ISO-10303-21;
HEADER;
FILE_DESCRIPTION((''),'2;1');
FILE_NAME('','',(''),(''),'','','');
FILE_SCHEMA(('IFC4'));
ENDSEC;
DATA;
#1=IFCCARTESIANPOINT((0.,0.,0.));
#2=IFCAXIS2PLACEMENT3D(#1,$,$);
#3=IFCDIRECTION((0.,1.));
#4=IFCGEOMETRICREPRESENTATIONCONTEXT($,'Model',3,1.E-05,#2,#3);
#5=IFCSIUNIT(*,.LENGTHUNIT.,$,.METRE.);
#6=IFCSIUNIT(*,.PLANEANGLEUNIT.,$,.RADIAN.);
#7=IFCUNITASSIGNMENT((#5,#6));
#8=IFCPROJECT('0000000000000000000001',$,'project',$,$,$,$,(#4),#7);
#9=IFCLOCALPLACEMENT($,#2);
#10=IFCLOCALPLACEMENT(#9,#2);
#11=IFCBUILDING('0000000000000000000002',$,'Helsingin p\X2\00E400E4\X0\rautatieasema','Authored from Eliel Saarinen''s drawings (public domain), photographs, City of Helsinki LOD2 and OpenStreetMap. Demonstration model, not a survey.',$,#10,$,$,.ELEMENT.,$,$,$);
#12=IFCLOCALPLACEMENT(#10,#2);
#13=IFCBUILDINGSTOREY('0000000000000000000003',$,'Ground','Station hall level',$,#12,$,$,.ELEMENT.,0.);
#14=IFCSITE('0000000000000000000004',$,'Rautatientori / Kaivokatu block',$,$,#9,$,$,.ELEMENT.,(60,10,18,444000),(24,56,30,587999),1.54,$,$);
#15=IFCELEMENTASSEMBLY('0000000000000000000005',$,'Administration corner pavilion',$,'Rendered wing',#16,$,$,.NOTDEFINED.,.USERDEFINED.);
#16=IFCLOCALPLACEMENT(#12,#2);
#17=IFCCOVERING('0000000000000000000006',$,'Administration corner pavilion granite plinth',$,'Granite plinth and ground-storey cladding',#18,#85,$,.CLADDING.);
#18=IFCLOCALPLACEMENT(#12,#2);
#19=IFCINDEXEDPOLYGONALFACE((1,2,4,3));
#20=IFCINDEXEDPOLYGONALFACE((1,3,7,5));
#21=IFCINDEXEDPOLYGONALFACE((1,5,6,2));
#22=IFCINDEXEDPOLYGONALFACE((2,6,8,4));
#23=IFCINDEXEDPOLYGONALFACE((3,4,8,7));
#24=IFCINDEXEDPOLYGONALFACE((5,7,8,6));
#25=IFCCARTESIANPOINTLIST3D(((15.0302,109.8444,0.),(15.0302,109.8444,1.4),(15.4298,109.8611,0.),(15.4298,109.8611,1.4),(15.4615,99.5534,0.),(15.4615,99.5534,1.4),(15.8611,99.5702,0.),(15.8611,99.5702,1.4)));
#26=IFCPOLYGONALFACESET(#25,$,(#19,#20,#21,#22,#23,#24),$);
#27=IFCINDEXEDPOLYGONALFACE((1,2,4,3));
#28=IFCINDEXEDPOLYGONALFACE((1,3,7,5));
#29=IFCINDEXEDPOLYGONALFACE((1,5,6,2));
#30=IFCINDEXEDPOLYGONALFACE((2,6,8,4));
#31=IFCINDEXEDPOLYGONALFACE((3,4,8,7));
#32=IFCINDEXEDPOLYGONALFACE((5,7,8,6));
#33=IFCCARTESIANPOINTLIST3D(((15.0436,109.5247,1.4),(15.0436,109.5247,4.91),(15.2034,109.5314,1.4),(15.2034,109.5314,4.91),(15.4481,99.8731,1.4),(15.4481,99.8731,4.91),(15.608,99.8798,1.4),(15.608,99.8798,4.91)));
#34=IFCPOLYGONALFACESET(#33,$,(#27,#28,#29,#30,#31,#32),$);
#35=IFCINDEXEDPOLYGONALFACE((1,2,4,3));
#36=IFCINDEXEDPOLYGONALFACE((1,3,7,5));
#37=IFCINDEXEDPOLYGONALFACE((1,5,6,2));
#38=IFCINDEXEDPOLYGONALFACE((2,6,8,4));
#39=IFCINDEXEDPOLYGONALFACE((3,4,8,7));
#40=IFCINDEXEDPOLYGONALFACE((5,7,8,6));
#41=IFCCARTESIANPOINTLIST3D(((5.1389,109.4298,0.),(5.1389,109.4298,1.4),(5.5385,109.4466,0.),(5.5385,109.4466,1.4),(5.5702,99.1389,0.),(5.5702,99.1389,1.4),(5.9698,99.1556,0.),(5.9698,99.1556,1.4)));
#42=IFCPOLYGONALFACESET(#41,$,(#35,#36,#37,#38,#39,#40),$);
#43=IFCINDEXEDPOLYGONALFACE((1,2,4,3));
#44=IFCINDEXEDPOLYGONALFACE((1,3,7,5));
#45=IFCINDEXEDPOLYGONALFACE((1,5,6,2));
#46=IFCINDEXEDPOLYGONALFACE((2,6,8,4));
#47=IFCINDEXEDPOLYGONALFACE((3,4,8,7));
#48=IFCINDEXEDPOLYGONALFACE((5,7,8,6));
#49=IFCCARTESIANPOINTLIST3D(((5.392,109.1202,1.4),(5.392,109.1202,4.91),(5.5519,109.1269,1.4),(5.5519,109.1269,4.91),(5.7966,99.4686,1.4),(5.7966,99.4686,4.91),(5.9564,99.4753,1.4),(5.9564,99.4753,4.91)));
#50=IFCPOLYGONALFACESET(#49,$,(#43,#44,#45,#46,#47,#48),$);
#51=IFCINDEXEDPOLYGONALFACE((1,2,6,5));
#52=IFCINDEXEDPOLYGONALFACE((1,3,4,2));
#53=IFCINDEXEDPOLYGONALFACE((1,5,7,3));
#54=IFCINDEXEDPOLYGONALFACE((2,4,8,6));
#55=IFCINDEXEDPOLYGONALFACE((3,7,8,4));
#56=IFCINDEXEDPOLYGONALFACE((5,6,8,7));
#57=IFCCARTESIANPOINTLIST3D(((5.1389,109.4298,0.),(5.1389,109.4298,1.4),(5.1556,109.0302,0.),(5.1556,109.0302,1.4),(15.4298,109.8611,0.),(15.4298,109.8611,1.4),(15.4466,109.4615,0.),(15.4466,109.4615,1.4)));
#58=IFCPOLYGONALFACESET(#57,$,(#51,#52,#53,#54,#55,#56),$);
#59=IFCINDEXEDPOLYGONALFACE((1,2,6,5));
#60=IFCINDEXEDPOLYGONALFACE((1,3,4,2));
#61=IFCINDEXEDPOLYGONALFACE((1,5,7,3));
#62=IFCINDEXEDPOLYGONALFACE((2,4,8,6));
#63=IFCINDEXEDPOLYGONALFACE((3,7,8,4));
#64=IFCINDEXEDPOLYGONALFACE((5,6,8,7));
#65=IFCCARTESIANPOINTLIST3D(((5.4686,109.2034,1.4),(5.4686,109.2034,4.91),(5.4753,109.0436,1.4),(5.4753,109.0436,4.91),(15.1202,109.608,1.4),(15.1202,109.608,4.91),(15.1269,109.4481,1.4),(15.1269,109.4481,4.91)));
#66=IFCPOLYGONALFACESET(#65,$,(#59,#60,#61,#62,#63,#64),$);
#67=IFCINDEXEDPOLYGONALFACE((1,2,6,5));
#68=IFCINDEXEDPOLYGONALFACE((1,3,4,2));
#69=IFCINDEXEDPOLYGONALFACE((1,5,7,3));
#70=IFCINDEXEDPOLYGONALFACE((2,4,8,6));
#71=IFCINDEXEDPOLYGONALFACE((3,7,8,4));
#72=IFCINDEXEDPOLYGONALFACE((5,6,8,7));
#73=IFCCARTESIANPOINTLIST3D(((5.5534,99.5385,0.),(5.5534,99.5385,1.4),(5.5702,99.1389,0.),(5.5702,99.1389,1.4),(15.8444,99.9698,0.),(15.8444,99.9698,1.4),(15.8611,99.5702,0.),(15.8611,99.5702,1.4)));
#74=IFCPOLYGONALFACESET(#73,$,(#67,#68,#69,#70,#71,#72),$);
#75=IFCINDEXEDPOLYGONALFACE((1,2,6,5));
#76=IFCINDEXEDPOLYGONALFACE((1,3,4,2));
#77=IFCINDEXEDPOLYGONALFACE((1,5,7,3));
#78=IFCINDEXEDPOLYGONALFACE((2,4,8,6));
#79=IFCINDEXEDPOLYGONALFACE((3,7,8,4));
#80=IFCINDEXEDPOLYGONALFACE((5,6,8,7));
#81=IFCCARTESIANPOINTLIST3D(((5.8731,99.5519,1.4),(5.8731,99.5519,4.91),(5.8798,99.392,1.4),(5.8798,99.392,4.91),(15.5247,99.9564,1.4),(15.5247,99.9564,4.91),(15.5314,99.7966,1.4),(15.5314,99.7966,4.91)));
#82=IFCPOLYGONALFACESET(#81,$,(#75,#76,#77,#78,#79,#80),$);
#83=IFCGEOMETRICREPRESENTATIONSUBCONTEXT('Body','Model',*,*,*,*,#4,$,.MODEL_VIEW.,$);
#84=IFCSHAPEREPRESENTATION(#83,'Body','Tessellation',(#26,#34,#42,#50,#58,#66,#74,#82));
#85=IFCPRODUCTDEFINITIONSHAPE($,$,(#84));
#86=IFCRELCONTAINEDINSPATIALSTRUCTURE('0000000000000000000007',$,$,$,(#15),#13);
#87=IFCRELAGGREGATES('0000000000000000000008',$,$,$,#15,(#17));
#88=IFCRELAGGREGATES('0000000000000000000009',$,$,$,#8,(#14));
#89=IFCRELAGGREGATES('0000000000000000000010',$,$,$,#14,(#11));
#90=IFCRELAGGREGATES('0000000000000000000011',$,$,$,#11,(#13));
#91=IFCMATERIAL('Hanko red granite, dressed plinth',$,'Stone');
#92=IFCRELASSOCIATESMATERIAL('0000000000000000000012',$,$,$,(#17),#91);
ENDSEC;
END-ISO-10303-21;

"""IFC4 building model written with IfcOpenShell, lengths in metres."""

from ifc_helpers import new_model, si_unit, direction, frame, frame_2d, origin, place, context, subcontext, project, spatial, rectangle, extrude, material, element, aggregate, save


model = new_model("IFC4")

# Units and contexts
model_context = context("Model", 3, precision=1e-05, world=origin(), true_north=direction((0.0, 1.0)))
body_context = subcontext(model_context, "Body", "Model", "MODEL_VIEW")
ifc_project = project(units=[si_unit("LENGTHUNIT", "METRE"), si_unit("PLANEANGLEUNIT", "RADIAN")], contexts=[model_context])

# Site, building, storey
site_placement = place(None, origin())
site = spatial("IfcSite", under=ifc_project, at=site_placement, Name="Rautatientori / Kaivokatu block", CompositionType="ELEMENT", RefLatitude=(60, 10, 18, 444000), RefLongitude=(24, 56, 30, 587999), RefElevation=1.54)
building_placement = place(site_placement, origin())
building = spatial("IfcBuilding", under=site, at=building_placement, Name="Helsingin päärautatieasema", Description="Authored from Eliel Saarinen's drawings (public domain), photographs, City of Helsinki LOD2 and OpenStreetMap. Demonstration model, not a survey.", CompositionType="ELEMENT")
storey_placement = place(building_placement, origin())
storey = spatial("IfcBuildingStorey", under=building, at=storey_placement, Name="Ground", Description="Station hall level", CompositionType="ELEMENT", Elevation=0.0)

# Element assembly, covering
assembly_placement = place(building_placement, origin())
assembly = element("IfcElementAssembly", 1, at=assembly_placement, inside=storey, Name="Administration corner pavilion", ObjectType="Rendered wing", AssemblyPlace="NOTDEFINED", PredefinedType="USERDEFINED")
ifc_material_1 = material(Name="Hanko red granite, dressed plinth", Category="Stone")
covering_placement = place(building_placement, origin())
covering = element("IfcCovering", 2, at=covering_placement, material=ifc_material_1, Name="Administration corner pavilion granite plinth", ObjectType="Granite plinth and ground-storey cladding", PredefinedType="CLADDING", context=body_context, shape_type="SweptSolid", body=[
    extrude(rectangle(XDim=10.3, YDim=0.4, at=frame_2d((0.0, 0.0), x_axis=(-0.041876, 0.999123))), frame((15.4457, 104.7073, 0.0)), (0.0, 0.0, 1.0), 1.4),
    extrude(rectangle(XDim=9.66, YDim=0.16, at=frame_2d((0.0, 0.0), x_axis=(-0.041876, 0.999123))), frame((15.3258, 104.7023, 1.4)), (0.0, 0.0, 1.0), 3.51),
    extrude(rectangle(XDim=10.3, YDim=0.4, at=frame_2d((0.0, 0.0), x_axis=(0.041876, -0.999123))), frame((5.5543, 104.2927, 0.0)), (0.0, 0.0, 1.0), 1.4),
    extrude(rectangle(XDim=9.66, YDim=0.16, at=frame_2d((0.0, 0.0), x_axis=(0.041876, -0.999123))), frame((5.6742, 104.2977, 1.4)), (0.0, 0.0, 1.0), 3.51),
    extrude(rectangle(XDim=10.3, YDim=0.4, at=frame_2d((0.0, 0.0), x_axis=(-0.999123, -0.041876))), frame((10.2927, 109.4457, 0.0)), (0.0, 0.0, 1.0), 1.4),
    extrude(rectangle(XDim=9.66, YDim=0.16, at=frame_2d((0.0, 0.0), x_axis=(-0.999123, -0.041876))), frame((10.2977, 109.3258, 1.4)), (0.0, 0.0, 1.0), 3.51),
    extrude(rectangle(XDim=10.3, YDim=0.4, at=frame_2d((0.0, 0.0), x_axis=(0.999123, 0.041876))), frame((10.7073, 99.5543, 0.0)), (0.0, 0.0, 1.0), 1.4),
    extrude(rectangle(XDim=9.66, YDim=0.16, at=frame_2d((0.0, 0.0), x_axis=(0.999123, 0.041876))), frame((10.7023, 99.6742, 1.4)), (0.0, 0.0, 1.0), 3.51),
])
aggregate(assembly, [covering])

save(model, "model.ifc")
